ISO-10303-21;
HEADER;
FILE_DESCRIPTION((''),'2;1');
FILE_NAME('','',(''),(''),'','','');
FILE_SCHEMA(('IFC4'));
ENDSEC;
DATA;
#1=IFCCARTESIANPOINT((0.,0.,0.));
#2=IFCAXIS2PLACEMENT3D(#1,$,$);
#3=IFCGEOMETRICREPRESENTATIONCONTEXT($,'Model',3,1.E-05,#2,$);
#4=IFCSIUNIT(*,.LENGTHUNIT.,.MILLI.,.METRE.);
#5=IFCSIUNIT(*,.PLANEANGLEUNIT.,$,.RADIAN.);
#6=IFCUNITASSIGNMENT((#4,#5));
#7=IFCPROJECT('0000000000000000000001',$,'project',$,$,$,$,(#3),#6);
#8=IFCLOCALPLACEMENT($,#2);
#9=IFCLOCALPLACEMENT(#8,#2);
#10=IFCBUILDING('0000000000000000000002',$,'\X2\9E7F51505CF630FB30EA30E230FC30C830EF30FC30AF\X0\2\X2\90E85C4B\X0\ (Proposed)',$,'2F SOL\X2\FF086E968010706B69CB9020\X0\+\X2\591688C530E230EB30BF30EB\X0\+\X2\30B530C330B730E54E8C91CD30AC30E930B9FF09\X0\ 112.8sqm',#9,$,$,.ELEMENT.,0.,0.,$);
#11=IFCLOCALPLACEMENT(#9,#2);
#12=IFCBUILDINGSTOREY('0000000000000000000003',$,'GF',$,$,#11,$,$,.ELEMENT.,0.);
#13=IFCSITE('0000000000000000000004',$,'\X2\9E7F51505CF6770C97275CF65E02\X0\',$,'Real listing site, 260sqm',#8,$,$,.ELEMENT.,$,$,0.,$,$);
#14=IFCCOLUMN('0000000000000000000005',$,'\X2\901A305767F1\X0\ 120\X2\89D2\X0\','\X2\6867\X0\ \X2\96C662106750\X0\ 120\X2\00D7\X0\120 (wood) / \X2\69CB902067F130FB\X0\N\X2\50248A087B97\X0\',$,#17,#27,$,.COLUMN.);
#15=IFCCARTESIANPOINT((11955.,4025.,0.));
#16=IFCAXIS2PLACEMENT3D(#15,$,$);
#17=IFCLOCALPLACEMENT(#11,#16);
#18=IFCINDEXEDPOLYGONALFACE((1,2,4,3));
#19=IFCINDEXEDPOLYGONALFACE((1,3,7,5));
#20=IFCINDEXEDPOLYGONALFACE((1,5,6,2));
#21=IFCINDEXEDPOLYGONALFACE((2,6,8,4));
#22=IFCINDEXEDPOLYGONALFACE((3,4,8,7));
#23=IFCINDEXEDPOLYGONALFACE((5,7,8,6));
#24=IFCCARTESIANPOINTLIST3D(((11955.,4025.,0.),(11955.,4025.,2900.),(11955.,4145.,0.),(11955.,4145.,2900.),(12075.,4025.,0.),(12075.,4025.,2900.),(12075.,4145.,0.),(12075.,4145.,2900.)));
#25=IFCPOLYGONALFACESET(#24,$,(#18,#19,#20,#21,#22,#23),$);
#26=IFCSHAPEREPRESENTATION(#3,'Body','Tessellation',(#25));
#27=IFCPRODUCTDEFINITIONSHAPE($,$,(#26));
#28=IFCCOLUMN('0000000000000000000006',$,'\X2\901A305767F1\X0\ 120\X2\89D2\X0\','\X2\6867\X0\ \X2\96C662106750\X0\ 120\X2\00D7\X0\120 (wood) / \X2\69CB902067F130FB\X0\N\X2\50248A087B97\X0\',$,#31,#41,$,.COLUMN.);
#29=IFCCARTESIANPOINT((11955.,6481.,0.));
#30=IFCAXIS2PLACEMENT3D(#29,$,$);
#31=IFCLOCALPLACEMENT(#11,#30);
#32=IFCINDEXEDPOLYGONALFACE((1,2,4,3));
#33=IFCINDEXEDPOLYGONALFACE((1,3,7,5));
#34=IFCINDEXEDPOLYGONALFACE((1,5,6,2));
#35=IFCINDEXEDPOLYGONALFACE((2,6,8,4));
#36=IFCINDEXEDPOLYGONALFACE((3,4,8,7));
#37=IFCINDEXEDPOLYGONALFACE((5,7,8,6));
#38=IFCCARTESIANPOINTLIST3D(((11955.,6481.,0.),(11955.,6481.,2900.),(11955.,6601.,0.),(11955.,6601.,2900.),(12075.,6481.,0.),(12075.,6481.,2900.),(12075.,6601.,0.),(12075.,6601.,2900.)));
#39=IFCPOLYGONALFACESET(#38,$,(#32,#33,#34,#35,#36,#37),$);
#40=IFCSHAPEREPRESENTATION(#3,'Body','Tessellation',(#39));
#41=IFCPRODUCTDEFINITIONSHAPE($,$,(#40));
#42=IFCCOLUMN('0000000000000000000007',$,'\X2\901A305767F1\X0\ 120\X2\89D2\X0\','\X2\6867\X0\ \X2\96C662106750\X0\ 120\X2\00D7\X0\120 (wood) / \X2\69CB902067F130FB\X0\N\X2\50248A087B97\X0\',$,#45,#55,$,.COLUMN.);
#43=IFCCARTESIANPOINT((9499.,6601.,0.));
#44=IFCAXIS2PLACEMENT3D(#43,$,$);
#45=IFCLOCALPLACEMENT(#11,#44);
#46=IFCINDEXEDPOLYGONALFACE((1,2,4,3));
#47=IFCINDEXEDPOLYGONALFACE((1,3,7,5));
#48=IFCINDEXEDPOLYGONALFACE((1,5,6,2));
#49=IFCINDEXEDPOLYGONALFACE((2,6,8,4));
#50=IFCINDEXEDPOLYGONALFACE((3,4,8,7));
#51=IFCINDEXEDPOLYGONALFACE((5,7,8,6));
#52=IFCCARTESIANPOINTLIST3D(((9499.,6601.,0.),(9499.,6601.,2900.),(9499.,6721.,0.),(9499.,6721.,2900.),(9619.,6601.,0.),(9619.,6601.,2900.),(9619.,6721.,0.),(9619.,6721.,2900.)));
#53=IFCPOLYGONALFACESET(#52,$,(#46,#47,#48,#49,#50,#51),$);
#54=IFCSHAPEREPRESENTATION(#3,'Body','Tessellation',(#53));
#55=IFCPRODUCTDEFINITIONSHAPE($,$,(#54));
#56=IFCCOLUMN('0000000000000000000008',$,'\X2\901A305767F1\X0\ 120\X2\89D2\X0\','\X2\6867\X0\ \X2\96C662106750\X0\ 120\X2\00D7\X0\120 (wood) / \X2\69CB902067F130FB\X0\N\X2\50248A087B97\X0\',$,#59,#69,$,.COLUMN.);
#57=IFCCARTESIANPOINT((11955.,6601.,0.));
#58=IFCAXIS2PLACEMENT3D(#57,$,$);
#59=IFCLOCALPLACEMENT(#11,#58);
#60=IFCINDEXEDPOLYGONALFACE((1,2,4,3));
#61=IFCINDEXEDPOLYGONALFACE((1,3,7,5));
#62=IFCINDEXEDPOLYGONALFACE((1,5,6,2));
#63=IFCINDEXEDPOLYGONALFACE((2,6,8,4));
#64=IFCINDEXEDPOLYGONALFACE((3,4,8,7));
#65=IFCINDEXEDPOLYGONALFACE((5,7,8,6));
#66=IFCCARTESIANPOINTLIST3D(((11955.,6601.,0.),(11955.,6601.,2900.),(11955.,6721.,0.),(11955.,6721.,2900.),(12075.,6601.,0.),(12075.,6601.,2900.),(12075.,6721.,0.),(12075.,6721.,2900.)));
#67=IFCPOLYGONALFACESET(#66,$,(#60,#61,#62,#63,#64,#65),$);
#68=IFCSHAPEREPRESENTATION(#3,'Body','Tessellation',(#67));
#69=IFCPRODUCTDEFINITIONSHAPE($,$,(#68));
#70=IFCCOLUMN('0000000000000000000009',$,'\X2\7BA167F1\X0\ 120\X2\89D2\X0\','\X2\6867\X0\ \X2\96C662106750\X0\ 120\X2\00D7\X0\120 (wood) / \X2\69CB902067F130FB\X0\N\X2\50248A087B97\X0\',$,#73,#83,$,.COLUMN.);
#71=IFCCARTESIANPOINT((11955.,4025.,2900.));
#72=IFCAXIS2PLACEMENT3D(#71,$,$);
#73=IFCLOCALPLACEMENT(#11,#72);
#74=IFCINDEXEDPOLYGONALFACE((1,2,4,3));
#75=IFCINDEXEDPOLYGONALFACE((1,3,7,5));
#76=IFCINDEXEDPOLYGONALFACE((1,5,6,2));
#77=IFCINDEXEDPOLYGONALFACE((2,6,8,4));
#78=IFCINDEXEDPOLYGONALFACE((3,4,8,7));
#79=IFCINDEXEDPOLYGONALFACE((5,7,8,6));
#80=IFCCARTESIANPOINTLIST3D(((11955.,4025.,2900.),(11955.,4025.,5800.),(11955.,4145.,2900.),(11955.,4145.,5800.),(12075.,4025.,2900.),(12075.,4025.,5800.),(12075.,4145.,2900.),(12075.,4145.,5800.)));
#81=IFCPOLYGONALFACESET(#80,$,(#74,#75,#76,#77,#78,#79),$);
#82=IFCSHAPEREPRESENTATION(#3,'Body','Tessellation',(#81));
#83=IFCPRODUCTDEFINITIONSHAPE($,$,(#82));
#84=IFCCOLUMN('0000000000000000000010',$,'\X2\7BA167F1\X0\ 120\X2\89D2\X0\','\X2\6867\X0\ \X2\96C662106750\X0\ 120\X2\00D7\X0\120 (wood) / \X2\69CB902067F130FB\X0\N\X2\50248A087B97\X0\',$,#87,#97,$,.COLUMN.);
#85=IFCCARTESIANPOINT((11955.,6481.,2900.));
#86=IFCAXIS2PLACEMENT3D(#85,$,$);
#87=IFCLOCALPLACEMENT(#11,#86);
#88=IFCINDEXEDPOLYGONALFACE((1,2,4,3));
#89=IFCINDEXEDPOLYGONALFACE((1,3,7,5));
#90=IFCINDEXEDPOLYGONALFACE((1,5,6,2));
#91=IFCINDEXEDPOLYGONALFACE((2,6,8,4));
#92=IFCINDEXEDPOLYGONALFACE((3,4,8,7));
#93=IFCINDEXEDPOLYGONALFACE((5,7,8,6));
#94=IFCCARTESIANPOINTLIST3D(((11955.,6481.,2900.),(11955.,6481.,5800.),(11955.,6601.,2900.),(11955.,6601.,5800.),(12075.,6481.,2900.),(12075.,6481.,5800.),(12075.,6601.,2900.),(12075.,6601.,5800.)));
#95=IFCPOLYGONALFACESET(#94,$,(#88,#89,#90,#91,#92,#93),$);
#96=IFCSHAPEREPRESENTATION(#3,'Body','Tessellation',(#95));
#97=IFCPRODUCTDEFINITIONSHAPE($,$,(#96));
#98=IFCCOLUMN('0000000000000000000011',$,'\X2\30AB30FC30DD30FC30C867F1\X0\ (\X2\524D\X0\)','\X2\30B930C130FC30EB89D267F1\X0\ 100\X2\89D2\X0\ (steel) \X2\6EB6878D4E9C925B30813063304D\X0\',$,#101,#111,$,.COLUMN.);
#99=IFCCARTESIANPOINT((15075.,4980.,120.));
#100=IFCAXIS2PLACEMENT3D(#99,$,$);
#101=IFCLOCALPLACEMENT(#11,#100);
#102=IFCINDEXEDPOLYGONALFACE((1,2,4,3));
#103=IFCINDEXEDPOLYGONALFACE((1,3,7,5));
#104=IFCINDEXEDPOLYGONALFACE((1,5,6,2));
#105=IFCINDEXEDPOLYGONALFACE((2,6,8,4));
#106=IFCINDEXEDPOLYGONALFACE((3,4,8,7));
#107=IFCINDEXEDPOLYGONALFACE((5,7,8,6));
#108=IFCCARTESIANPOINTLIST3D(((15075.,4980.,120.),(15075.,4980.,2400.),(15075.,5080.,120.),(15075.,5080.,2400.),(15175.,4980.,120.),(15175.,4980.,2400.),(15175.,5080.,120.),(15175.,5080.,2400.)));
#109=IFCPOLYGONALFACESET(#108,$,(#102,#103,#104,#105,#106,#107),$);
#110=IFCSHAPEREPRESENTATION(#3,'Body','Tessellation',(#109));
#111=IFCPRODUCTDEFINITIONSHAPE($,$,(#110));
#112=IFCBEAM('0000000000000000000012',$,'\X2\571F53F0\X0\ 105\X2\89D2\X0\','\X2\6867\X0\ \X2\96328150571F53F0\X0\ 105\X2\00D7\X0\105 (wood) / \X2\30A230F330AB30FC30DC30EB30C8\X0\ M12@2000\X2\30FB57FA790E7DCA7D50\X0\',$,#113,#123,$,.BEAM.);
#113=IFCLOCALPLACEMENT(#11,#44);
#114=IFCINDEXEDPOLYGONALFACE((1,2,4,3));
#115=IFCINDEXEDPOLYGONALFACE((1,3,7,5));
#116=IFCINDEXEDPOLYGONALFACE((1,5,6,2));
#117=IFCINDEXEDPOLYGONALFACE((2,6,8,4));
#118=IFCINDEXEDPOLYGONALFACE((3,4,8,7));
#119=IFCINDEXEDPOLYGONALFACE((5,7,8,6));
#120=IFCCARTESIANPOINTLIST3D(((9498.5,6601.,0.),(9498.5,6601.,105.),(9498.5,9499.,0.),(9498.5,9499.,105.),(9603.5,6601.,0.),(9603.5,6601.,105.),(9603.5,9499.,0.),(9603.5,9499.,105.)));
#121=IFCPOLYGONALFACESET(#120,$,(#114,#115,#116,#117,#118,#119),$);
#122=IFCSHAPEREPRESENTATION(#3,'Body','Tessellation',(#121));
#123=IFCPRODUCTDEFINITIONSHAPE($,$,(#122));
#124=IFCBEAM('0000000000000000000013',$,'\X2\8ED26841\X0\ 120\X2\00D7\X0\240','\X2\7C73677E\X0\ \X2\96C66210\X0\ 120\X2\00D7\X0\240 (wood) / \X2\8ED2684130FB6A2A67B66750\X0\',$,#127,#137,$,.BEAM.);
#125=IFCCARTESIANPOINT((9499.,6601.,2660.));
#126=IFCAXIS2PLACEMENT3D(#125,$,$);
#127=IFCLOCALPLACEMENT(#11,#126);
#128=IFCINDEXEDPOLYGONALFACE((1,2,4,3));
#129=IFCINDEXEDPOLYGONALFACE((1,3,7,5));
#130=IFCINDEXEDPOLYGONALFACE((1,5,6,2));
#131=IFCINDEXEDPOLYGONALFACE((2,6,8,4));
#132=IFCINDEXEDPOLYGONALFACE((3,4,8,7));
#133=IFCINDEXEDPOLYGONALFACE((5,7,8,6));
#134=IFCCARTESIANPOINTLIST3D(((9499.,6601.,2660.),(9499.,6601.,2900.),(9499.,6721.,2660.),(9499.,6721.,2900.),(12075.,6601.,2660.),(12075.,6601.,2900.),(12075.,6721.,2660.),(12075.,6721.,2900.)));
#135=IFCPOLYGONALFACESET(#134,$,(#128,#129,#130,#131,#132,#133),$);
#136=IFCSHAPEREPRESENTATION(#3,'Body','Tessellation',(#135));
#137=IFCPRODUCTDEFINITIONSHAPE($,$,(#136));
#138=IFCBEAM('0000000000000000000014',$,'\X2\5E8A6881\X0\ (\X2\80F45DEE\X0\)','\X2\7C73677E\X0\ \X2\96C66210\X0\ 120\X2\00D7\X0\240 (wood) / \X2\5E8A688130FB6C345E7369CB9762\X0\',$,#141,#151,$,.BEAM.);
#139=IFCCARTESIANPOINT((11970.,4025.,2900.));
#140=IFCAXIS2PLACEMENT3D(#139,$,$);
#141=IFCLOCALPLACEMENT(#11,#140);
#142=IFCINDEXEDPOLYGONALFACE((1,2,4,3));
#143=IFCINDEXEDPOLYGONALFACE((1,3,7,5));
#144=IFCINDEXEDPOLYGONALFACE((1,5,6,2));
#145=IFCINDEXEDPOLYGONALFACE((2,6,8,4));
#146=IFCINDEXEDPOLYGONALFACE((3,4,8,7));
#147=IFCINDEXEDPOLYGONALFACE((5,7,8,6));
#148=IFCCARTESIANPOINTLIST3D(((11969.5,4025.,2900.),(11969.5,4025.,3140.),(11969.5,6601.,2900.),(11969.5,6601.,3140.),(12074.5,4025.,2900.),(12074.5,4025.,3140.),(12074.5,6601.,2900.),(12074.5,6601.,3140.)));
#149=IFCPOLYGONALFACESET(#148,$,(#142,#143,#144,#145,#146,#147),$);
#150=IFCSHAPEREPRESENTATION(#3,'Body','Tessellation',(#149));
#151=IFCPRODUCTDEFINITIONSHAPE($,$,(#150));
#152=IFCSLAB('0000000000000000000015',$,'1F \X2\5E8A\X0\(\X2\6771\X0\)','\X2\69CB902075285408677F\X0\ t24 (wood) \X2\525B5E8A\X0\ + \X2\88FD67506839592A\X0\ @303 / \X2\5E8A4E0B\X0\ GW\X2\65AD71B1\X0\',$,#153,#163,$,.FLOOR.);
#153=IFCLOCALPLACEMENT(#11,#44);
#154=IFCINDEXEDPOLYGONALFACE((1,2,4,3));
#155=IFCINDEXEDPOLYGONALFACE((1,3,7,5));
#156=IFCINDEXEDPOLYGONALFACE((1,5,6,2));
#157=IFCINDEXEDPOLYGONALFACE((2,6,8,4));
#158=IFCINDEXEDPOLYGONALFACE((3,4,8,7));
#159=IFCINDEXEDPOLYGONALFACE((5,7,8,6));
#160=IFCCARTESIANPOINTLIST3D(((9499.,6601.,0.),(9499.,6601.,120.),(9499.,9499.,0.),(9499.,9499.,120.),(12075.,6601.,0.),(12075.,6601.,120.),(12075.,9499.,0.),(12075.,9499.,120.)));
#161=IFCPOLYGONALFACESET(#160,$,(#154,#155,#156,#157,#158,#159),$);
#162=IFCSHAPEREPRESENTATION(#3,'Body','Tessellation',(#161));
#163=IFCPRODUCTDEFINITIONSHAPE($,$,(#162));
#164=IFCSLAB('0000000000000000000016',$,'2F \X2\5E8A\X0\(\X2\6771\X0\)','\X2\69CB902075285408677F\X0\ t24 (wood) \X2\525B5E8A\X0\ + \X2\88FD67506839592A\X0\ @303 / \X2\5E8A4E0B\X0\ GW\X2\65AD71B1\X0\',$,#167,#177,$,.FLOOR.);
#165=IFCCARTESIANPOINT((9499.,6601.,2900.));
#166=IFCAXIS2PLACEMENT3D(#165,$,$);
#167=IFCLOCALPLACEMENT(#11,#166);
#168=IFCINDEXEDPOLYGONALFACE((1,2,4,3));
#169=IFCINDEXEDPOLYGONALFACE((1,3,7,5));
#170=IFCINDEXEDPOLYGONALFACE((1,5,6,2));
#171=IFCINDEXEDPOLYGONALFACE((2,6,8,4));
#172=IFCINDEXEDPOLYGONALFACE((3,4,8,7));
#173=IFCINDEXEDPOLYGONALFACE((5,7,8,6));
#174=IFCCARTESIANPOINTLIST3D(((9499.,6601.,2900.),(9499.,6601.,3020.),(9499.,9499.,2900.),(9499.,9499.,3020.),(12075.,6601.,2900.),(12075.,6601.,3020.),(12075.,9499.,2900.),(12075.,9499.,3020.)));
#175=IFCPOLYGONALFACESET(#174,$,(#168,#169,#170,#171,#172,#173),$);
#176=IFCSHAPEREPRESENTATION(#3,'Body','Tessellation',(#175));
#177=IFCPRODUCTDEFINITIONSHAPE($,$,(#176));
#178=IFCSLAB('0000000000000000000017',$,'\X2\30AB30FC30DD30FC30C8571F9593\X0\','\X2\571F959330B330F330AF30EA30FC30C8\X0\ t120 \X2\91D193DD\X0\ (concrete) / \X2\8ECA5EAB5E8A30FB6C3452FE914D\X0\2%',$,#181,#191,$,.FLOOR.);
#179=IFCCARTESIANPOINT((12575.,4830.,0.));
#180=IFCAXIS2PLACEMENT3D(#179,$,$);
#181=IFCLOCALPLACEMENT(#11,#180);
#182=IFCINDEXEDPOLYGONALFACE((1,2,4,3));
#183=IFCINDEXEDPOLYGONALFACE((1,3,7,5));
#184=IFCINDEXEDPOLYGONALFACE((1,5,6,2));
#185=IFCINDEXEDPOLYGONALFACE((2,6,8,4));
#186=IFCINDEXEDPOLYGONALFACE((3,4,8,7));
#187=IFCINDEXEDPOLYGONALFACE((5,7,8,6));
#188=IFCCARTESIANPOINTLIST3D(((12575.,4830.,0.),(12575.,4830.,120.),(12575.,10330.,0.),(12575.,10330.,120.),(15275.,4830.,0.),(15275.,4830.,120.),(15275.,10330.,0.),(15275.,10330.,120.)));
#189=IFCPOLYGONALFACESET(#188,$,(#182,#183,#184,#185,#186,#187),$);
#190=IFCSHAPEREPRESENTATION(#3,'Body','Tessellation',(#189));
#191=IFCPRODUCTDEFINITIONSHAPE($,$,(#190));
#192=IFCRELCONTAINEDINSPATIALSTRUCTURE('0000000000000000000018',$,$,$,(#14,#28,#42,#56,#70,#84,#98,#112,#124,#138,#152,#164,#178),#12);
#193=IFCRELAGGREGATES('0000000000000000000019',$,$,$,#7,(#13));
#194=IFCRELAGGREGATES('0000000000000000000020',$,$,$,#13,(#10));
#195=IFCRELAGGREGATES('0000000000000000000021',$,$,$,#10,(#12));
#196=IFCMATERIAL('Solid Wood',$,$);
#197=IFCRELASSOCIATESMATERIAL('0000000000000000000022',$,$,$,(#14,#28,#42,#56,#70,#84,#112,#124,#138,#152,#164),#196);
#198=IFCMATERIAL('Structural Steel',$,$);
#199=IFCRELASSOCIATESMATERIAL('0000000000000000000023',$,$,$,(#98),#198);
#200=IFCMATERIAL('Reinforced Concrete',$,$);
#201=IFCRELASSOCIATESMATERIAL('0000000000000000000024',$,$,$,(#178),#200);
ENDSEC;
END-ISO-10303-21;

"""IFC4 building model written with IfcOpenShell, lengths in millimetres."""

from ifc_helpers import new_model, si_unit, frame, frame_2d, origin, place, context, project, spatial, rectangle, extrude, material, element, save


model = new_model("IFC4")

# Units and contexts
model_context = context("Model", 3, precision=1e-05, world=origin())
ifc_project = project(units=[si_unit("LENGTHUNIT", "METRE", prefix="MILLI"), si_unit("PLANEANGLEUNIT", "RADIAN")], contexts=[model_context])

# Site, building, storey
site_placement = place(None, origin())
site = spatial("IfcSite", under=ifc_project, at=site_placement, Name="鹿児島県霧島市", ObjectType="Real listing site, 260sqm", CompositionType="ELEMENT", RefElevation=0.0)
building_placement = place(site_placement, origin())
building = spatial("IfcBuilding", under=site, at=building_placement, Name="鹿児島・リモートワーク2部屋 (Proposed)", ObjectType="2F SOL（準耐火構造+外装モルタル+サッシュ二重ガラス） 112.8sqm", CompositionType="ELEMENT", ElevationOfRefHeight=0.0, ElevationOfTerrain=0.0)
storey_placement = place(building_placement, origin())
storey = spatial("IfcBuildingStorey", under=building, at=storey_placement, Name="GF", CompositionType="ELEMENT", Elevation=0.0)

# Columns
ifc_material_1 = material(Name="Solid Wood")
column_1_placement = place(storey_placement, frame((11955.0, 4025.0, 0.0)))
element("IfcColumn", 1, at=column_1_placement, inside=storey, material=ifc_material_1, Name="通し柱 120角", Description="桧 集成材 120×120 (wood) / 構造柱・N値計算", PredefinedType="COLUMN", context=model_context, shape_type="SweptSolid", body=[
    extrude(rectangle(XDim=120.0, YDim=120.0, at=frame_2d((60.0, 60.0))), frame((11955.0, 4025.0, 0.0)), (0.0, 0.0, 1.0), 2900.0),
])
column_2_placement = place(storey_placement, frame((11955.0, 6481.0, 0.0)))
element("IfcColumn", 2, at=column_2_placement, inside=storey, material=ifc_material_1, Name="通し柱 120角", Description="桧 集成材 120×120 (wood) / 構造柱・N値計算", PredefinedType="COLUMN", context=model_context, shape_type="SweptSolid", body=[
    extrude(rectangle(XDim=120.0, YDim=120.0, at=frame_2d((60.0, 60.0))), frame((11955.0, 6481.0, 0.0)), (0.0, 0.0, 1.0), 2900.0),
])
column_3_placement = place(storey_placement, frame((9499.0, 6601.0, 0.0)))
element("IfcColumn", 3, at=column_3_placement, inside=storey, material=ifc_material_1, Name="通し柱 120角", Description="桧 集成材 120×120 (wood) / 構造柱・N値計算", PredefinedType="COLUMN", context=model_context, shape_type="SweptSolid", body=[
    extrude(rectangle(XDim=120.0, YDim=120.0, at=frame_2d((60.0, 60.0))), frame((9499.0, 6601.0, 0.0)), (0.0, 0.0, 1.0), 2900.0),
])
column_4_placement = place(storey_placement, frame((11955.0, 6601.0, 0.0)))
element("IfcColumn", 4, at=column_4_placement, inside=storey, material=ifc_material_1, Name="通し柱 120角", Description="桧 集成材 120×120 (wood) / 構造柱・N値計算", PredefinedType="COLUMN", context=model_context, shape_type="SweptSolid", body=[
    extrude(rectangle(XDim=120.0, YDim=120.0, at=frame_2d((60.0, 60.0))), frame((11955.0, 6601.0, 0.0)), (0.0, 0.0, 1.0), 2900.0),
])
column_5_placement = place(storey_placement, frame((11955.0, 4025.0, 2900.0)))
element("IfcColumn", 5, at=column_5_placement, inside=storey, material=ifc_material_1, Name="管柱 120角", Description="桧 集成材 120×120 (wood) / 構造柱・N値計算", PredefinedType="COLUMN", context=model_context, shape_type="SweptSolid", body=[
    extrude(rectangle(XDim=120.0, YDim=120.0, at=frame_2d((60.0, 60.0))), frame((11955.0, 4025.0, 2900.0)), (0.0, 0.0, 1.0), 2900.0),
])
column_6_placement = place(storey_placement, frame((11955.0, 6481.0, 2900.0)))
element("IfcColumn", 6, at=column_6_placement, inside=storey, material=ifc_material_1, Name="管柱 120角", Description="桧 集成材 120×120 (wood) / 構造柱・N値計算", PredefinedType="COLUMN", context=model_context, shape_type="SweptSolid", body=[
    extrude(rectangle(XDim=120.0, YDim=120.0, at=frame_2d((60.0, 60.0))), frame((11955.0, 6481.0, 2900.0)), (0.0, 0.0, 1.0), 2900.0),
])
ifc_material_2 = material(Name="Structural Steel")
column_7_placement = place(storey_placement, frame((15075.0, 4980.0, 120.0)))
element("IfcColumn", 7, at=column_7_placement, inside=storey, material=ifc_material_2, Name="カーポート柱 (前)", Description="スチール角柱 100角 (steel) 溶融亜鉛めっき", PredefinedType="COLUMN", context=model_context, shape_type="SweptSolid", body=[
    extrude(rectangle(XDim=100.0, YDim=100.0, at=frame_2d((50.0, 50.0))), frame((15075.0, 4980.0, 120.0)), (0.0, 0.0, 1.0), 2280.0),
])

# Beams
beam_1_placement = place(storey_placement, frame((9499.0, 6601.0, 0.0)))
element("IfcBeam", 8, at=beam_1_placement, inside=storey, material=ifc_material_1, Name="土台 105角", Description="桧 防腐土台 105×105 (wood) / アンカーボルト M12@2000・基礎緊結", PredefinedType="BEAM", context=model_context, shape_type="SweptSolid", body=[
    extrude(rectangle(XDim=105.0, YDim=2898.0, at=frame_2d((52.0, 1449.0))), frame((9499.0, 6601.0, 0.0)), (0.0, 0.0, 1.0), 105.0),
])
beam_2_placement = place(storey_placement, frame((9499.0, 6601.0, 2660.0)))
element("IfcBeam", 9, at=beam_2_placement, inside=storey, material=ifc_material_1, Name="軒桁 120×240", Description="米松 集成 120×240 (wood) / 軒桁・横架材", PredefinedType="BEAM", context=model_context, shape_type="SweptSolid", body=[
    extrude(rectangle(XDim=2576.0, YDim=120.0, at=frame_2d((1288.0, 60.0))), frame((9499.0, 6601.0, 2660.0)), (0.0, 0.0, 1.0), 240.0),
])
beam_3_placement = place(storey_placement, frame((11970.0, 4025.0, 2900.0)))
element("IfcBeam", 10, at=beam_3_placement, inside=storey, material=ifc_material_1, Name="床梁 (胴差)", Description="米松 集成 120×240 (wood) / 床梁・水平構面", PredefinedType="BEAM", context=model_context, shape_type="SweptSolid", body=[
    extrude(rectangle(XDim=105.0, YDim=2576.0, at=frame_2d((52.0, 1288.0))), frame((11970.0, 4025.0, 2900.0)), (0.0, 0.0, 1.0), 240.0),
])

# Slabs
slab_1_placement = place(storey_placement, frame((9499.0, 6601.0, 0.0)))
element("IfcSlab", 11, at=slab_1_placement, inside=storey, material=ifc_material_1, Name="1F 床(東)", Description="構造用合板 t24 (wood) 剛床 + 製材根太 @303 / 床下 GW断熱", PredefinedType="FLOOR", context=model_context, shape_type="SweptSolid", body=[
    extrude(rectangle(XDim=2576.0, YDim=2898.0, at=frame_2d((1288.0, 1449.0))), frame((9499.0, 6601.0, 0.0)), (0.0, 0.0, 1.0), 120.0),
])
slab_2_placement = place(storey_placement, frame((9499.0, 6601.0, 2900.0)))
element("IfcSlab", 12, at=slab_2_placement, inside=storey, material=ifc_material_1, Name="2F 床(東)", Description="構造用合板 t24 (wood) 剛床 + 製材根太 @303 / 床下 GW断熱", PredefinedType="FLOOR", context=model_context, shape_type="SweptSolid", body=[
    extrude(rectangle(XDim=2576.0, YDim=2898.0, at=frame_2d((1288.0, 1449.0))), frame((9499.0, 6601.0, 2900.0)), (0.0, 0.0, 1.0), 120.0),
])
ifc_material_3 = material(Name="Reinforced Concrete")
slab_3_placement = place(storey_placement, frame((12575.0, 4830.0, 0.0)))
element("IfcSlab", 13, at=slab_3_placement, inside=storey, material=ifc_material_3, Name="カーポート土間", Description="土間コンクリート t120 金鏝 (concrete) / 車庫床・水勾配2%", PredefinedType="FLOOR", context=model_context, shape_type="SweptSolid", body=[
    extrude(rectangle(XDim=2700.0, YDim=5500.0, at=frame_2d((1350.0, 2750.0))), frame((12575.0, 4830.0, 0.0)), (0.0, 0.0, 1.0), 120.0),
])

save(model, "model.ifc")
